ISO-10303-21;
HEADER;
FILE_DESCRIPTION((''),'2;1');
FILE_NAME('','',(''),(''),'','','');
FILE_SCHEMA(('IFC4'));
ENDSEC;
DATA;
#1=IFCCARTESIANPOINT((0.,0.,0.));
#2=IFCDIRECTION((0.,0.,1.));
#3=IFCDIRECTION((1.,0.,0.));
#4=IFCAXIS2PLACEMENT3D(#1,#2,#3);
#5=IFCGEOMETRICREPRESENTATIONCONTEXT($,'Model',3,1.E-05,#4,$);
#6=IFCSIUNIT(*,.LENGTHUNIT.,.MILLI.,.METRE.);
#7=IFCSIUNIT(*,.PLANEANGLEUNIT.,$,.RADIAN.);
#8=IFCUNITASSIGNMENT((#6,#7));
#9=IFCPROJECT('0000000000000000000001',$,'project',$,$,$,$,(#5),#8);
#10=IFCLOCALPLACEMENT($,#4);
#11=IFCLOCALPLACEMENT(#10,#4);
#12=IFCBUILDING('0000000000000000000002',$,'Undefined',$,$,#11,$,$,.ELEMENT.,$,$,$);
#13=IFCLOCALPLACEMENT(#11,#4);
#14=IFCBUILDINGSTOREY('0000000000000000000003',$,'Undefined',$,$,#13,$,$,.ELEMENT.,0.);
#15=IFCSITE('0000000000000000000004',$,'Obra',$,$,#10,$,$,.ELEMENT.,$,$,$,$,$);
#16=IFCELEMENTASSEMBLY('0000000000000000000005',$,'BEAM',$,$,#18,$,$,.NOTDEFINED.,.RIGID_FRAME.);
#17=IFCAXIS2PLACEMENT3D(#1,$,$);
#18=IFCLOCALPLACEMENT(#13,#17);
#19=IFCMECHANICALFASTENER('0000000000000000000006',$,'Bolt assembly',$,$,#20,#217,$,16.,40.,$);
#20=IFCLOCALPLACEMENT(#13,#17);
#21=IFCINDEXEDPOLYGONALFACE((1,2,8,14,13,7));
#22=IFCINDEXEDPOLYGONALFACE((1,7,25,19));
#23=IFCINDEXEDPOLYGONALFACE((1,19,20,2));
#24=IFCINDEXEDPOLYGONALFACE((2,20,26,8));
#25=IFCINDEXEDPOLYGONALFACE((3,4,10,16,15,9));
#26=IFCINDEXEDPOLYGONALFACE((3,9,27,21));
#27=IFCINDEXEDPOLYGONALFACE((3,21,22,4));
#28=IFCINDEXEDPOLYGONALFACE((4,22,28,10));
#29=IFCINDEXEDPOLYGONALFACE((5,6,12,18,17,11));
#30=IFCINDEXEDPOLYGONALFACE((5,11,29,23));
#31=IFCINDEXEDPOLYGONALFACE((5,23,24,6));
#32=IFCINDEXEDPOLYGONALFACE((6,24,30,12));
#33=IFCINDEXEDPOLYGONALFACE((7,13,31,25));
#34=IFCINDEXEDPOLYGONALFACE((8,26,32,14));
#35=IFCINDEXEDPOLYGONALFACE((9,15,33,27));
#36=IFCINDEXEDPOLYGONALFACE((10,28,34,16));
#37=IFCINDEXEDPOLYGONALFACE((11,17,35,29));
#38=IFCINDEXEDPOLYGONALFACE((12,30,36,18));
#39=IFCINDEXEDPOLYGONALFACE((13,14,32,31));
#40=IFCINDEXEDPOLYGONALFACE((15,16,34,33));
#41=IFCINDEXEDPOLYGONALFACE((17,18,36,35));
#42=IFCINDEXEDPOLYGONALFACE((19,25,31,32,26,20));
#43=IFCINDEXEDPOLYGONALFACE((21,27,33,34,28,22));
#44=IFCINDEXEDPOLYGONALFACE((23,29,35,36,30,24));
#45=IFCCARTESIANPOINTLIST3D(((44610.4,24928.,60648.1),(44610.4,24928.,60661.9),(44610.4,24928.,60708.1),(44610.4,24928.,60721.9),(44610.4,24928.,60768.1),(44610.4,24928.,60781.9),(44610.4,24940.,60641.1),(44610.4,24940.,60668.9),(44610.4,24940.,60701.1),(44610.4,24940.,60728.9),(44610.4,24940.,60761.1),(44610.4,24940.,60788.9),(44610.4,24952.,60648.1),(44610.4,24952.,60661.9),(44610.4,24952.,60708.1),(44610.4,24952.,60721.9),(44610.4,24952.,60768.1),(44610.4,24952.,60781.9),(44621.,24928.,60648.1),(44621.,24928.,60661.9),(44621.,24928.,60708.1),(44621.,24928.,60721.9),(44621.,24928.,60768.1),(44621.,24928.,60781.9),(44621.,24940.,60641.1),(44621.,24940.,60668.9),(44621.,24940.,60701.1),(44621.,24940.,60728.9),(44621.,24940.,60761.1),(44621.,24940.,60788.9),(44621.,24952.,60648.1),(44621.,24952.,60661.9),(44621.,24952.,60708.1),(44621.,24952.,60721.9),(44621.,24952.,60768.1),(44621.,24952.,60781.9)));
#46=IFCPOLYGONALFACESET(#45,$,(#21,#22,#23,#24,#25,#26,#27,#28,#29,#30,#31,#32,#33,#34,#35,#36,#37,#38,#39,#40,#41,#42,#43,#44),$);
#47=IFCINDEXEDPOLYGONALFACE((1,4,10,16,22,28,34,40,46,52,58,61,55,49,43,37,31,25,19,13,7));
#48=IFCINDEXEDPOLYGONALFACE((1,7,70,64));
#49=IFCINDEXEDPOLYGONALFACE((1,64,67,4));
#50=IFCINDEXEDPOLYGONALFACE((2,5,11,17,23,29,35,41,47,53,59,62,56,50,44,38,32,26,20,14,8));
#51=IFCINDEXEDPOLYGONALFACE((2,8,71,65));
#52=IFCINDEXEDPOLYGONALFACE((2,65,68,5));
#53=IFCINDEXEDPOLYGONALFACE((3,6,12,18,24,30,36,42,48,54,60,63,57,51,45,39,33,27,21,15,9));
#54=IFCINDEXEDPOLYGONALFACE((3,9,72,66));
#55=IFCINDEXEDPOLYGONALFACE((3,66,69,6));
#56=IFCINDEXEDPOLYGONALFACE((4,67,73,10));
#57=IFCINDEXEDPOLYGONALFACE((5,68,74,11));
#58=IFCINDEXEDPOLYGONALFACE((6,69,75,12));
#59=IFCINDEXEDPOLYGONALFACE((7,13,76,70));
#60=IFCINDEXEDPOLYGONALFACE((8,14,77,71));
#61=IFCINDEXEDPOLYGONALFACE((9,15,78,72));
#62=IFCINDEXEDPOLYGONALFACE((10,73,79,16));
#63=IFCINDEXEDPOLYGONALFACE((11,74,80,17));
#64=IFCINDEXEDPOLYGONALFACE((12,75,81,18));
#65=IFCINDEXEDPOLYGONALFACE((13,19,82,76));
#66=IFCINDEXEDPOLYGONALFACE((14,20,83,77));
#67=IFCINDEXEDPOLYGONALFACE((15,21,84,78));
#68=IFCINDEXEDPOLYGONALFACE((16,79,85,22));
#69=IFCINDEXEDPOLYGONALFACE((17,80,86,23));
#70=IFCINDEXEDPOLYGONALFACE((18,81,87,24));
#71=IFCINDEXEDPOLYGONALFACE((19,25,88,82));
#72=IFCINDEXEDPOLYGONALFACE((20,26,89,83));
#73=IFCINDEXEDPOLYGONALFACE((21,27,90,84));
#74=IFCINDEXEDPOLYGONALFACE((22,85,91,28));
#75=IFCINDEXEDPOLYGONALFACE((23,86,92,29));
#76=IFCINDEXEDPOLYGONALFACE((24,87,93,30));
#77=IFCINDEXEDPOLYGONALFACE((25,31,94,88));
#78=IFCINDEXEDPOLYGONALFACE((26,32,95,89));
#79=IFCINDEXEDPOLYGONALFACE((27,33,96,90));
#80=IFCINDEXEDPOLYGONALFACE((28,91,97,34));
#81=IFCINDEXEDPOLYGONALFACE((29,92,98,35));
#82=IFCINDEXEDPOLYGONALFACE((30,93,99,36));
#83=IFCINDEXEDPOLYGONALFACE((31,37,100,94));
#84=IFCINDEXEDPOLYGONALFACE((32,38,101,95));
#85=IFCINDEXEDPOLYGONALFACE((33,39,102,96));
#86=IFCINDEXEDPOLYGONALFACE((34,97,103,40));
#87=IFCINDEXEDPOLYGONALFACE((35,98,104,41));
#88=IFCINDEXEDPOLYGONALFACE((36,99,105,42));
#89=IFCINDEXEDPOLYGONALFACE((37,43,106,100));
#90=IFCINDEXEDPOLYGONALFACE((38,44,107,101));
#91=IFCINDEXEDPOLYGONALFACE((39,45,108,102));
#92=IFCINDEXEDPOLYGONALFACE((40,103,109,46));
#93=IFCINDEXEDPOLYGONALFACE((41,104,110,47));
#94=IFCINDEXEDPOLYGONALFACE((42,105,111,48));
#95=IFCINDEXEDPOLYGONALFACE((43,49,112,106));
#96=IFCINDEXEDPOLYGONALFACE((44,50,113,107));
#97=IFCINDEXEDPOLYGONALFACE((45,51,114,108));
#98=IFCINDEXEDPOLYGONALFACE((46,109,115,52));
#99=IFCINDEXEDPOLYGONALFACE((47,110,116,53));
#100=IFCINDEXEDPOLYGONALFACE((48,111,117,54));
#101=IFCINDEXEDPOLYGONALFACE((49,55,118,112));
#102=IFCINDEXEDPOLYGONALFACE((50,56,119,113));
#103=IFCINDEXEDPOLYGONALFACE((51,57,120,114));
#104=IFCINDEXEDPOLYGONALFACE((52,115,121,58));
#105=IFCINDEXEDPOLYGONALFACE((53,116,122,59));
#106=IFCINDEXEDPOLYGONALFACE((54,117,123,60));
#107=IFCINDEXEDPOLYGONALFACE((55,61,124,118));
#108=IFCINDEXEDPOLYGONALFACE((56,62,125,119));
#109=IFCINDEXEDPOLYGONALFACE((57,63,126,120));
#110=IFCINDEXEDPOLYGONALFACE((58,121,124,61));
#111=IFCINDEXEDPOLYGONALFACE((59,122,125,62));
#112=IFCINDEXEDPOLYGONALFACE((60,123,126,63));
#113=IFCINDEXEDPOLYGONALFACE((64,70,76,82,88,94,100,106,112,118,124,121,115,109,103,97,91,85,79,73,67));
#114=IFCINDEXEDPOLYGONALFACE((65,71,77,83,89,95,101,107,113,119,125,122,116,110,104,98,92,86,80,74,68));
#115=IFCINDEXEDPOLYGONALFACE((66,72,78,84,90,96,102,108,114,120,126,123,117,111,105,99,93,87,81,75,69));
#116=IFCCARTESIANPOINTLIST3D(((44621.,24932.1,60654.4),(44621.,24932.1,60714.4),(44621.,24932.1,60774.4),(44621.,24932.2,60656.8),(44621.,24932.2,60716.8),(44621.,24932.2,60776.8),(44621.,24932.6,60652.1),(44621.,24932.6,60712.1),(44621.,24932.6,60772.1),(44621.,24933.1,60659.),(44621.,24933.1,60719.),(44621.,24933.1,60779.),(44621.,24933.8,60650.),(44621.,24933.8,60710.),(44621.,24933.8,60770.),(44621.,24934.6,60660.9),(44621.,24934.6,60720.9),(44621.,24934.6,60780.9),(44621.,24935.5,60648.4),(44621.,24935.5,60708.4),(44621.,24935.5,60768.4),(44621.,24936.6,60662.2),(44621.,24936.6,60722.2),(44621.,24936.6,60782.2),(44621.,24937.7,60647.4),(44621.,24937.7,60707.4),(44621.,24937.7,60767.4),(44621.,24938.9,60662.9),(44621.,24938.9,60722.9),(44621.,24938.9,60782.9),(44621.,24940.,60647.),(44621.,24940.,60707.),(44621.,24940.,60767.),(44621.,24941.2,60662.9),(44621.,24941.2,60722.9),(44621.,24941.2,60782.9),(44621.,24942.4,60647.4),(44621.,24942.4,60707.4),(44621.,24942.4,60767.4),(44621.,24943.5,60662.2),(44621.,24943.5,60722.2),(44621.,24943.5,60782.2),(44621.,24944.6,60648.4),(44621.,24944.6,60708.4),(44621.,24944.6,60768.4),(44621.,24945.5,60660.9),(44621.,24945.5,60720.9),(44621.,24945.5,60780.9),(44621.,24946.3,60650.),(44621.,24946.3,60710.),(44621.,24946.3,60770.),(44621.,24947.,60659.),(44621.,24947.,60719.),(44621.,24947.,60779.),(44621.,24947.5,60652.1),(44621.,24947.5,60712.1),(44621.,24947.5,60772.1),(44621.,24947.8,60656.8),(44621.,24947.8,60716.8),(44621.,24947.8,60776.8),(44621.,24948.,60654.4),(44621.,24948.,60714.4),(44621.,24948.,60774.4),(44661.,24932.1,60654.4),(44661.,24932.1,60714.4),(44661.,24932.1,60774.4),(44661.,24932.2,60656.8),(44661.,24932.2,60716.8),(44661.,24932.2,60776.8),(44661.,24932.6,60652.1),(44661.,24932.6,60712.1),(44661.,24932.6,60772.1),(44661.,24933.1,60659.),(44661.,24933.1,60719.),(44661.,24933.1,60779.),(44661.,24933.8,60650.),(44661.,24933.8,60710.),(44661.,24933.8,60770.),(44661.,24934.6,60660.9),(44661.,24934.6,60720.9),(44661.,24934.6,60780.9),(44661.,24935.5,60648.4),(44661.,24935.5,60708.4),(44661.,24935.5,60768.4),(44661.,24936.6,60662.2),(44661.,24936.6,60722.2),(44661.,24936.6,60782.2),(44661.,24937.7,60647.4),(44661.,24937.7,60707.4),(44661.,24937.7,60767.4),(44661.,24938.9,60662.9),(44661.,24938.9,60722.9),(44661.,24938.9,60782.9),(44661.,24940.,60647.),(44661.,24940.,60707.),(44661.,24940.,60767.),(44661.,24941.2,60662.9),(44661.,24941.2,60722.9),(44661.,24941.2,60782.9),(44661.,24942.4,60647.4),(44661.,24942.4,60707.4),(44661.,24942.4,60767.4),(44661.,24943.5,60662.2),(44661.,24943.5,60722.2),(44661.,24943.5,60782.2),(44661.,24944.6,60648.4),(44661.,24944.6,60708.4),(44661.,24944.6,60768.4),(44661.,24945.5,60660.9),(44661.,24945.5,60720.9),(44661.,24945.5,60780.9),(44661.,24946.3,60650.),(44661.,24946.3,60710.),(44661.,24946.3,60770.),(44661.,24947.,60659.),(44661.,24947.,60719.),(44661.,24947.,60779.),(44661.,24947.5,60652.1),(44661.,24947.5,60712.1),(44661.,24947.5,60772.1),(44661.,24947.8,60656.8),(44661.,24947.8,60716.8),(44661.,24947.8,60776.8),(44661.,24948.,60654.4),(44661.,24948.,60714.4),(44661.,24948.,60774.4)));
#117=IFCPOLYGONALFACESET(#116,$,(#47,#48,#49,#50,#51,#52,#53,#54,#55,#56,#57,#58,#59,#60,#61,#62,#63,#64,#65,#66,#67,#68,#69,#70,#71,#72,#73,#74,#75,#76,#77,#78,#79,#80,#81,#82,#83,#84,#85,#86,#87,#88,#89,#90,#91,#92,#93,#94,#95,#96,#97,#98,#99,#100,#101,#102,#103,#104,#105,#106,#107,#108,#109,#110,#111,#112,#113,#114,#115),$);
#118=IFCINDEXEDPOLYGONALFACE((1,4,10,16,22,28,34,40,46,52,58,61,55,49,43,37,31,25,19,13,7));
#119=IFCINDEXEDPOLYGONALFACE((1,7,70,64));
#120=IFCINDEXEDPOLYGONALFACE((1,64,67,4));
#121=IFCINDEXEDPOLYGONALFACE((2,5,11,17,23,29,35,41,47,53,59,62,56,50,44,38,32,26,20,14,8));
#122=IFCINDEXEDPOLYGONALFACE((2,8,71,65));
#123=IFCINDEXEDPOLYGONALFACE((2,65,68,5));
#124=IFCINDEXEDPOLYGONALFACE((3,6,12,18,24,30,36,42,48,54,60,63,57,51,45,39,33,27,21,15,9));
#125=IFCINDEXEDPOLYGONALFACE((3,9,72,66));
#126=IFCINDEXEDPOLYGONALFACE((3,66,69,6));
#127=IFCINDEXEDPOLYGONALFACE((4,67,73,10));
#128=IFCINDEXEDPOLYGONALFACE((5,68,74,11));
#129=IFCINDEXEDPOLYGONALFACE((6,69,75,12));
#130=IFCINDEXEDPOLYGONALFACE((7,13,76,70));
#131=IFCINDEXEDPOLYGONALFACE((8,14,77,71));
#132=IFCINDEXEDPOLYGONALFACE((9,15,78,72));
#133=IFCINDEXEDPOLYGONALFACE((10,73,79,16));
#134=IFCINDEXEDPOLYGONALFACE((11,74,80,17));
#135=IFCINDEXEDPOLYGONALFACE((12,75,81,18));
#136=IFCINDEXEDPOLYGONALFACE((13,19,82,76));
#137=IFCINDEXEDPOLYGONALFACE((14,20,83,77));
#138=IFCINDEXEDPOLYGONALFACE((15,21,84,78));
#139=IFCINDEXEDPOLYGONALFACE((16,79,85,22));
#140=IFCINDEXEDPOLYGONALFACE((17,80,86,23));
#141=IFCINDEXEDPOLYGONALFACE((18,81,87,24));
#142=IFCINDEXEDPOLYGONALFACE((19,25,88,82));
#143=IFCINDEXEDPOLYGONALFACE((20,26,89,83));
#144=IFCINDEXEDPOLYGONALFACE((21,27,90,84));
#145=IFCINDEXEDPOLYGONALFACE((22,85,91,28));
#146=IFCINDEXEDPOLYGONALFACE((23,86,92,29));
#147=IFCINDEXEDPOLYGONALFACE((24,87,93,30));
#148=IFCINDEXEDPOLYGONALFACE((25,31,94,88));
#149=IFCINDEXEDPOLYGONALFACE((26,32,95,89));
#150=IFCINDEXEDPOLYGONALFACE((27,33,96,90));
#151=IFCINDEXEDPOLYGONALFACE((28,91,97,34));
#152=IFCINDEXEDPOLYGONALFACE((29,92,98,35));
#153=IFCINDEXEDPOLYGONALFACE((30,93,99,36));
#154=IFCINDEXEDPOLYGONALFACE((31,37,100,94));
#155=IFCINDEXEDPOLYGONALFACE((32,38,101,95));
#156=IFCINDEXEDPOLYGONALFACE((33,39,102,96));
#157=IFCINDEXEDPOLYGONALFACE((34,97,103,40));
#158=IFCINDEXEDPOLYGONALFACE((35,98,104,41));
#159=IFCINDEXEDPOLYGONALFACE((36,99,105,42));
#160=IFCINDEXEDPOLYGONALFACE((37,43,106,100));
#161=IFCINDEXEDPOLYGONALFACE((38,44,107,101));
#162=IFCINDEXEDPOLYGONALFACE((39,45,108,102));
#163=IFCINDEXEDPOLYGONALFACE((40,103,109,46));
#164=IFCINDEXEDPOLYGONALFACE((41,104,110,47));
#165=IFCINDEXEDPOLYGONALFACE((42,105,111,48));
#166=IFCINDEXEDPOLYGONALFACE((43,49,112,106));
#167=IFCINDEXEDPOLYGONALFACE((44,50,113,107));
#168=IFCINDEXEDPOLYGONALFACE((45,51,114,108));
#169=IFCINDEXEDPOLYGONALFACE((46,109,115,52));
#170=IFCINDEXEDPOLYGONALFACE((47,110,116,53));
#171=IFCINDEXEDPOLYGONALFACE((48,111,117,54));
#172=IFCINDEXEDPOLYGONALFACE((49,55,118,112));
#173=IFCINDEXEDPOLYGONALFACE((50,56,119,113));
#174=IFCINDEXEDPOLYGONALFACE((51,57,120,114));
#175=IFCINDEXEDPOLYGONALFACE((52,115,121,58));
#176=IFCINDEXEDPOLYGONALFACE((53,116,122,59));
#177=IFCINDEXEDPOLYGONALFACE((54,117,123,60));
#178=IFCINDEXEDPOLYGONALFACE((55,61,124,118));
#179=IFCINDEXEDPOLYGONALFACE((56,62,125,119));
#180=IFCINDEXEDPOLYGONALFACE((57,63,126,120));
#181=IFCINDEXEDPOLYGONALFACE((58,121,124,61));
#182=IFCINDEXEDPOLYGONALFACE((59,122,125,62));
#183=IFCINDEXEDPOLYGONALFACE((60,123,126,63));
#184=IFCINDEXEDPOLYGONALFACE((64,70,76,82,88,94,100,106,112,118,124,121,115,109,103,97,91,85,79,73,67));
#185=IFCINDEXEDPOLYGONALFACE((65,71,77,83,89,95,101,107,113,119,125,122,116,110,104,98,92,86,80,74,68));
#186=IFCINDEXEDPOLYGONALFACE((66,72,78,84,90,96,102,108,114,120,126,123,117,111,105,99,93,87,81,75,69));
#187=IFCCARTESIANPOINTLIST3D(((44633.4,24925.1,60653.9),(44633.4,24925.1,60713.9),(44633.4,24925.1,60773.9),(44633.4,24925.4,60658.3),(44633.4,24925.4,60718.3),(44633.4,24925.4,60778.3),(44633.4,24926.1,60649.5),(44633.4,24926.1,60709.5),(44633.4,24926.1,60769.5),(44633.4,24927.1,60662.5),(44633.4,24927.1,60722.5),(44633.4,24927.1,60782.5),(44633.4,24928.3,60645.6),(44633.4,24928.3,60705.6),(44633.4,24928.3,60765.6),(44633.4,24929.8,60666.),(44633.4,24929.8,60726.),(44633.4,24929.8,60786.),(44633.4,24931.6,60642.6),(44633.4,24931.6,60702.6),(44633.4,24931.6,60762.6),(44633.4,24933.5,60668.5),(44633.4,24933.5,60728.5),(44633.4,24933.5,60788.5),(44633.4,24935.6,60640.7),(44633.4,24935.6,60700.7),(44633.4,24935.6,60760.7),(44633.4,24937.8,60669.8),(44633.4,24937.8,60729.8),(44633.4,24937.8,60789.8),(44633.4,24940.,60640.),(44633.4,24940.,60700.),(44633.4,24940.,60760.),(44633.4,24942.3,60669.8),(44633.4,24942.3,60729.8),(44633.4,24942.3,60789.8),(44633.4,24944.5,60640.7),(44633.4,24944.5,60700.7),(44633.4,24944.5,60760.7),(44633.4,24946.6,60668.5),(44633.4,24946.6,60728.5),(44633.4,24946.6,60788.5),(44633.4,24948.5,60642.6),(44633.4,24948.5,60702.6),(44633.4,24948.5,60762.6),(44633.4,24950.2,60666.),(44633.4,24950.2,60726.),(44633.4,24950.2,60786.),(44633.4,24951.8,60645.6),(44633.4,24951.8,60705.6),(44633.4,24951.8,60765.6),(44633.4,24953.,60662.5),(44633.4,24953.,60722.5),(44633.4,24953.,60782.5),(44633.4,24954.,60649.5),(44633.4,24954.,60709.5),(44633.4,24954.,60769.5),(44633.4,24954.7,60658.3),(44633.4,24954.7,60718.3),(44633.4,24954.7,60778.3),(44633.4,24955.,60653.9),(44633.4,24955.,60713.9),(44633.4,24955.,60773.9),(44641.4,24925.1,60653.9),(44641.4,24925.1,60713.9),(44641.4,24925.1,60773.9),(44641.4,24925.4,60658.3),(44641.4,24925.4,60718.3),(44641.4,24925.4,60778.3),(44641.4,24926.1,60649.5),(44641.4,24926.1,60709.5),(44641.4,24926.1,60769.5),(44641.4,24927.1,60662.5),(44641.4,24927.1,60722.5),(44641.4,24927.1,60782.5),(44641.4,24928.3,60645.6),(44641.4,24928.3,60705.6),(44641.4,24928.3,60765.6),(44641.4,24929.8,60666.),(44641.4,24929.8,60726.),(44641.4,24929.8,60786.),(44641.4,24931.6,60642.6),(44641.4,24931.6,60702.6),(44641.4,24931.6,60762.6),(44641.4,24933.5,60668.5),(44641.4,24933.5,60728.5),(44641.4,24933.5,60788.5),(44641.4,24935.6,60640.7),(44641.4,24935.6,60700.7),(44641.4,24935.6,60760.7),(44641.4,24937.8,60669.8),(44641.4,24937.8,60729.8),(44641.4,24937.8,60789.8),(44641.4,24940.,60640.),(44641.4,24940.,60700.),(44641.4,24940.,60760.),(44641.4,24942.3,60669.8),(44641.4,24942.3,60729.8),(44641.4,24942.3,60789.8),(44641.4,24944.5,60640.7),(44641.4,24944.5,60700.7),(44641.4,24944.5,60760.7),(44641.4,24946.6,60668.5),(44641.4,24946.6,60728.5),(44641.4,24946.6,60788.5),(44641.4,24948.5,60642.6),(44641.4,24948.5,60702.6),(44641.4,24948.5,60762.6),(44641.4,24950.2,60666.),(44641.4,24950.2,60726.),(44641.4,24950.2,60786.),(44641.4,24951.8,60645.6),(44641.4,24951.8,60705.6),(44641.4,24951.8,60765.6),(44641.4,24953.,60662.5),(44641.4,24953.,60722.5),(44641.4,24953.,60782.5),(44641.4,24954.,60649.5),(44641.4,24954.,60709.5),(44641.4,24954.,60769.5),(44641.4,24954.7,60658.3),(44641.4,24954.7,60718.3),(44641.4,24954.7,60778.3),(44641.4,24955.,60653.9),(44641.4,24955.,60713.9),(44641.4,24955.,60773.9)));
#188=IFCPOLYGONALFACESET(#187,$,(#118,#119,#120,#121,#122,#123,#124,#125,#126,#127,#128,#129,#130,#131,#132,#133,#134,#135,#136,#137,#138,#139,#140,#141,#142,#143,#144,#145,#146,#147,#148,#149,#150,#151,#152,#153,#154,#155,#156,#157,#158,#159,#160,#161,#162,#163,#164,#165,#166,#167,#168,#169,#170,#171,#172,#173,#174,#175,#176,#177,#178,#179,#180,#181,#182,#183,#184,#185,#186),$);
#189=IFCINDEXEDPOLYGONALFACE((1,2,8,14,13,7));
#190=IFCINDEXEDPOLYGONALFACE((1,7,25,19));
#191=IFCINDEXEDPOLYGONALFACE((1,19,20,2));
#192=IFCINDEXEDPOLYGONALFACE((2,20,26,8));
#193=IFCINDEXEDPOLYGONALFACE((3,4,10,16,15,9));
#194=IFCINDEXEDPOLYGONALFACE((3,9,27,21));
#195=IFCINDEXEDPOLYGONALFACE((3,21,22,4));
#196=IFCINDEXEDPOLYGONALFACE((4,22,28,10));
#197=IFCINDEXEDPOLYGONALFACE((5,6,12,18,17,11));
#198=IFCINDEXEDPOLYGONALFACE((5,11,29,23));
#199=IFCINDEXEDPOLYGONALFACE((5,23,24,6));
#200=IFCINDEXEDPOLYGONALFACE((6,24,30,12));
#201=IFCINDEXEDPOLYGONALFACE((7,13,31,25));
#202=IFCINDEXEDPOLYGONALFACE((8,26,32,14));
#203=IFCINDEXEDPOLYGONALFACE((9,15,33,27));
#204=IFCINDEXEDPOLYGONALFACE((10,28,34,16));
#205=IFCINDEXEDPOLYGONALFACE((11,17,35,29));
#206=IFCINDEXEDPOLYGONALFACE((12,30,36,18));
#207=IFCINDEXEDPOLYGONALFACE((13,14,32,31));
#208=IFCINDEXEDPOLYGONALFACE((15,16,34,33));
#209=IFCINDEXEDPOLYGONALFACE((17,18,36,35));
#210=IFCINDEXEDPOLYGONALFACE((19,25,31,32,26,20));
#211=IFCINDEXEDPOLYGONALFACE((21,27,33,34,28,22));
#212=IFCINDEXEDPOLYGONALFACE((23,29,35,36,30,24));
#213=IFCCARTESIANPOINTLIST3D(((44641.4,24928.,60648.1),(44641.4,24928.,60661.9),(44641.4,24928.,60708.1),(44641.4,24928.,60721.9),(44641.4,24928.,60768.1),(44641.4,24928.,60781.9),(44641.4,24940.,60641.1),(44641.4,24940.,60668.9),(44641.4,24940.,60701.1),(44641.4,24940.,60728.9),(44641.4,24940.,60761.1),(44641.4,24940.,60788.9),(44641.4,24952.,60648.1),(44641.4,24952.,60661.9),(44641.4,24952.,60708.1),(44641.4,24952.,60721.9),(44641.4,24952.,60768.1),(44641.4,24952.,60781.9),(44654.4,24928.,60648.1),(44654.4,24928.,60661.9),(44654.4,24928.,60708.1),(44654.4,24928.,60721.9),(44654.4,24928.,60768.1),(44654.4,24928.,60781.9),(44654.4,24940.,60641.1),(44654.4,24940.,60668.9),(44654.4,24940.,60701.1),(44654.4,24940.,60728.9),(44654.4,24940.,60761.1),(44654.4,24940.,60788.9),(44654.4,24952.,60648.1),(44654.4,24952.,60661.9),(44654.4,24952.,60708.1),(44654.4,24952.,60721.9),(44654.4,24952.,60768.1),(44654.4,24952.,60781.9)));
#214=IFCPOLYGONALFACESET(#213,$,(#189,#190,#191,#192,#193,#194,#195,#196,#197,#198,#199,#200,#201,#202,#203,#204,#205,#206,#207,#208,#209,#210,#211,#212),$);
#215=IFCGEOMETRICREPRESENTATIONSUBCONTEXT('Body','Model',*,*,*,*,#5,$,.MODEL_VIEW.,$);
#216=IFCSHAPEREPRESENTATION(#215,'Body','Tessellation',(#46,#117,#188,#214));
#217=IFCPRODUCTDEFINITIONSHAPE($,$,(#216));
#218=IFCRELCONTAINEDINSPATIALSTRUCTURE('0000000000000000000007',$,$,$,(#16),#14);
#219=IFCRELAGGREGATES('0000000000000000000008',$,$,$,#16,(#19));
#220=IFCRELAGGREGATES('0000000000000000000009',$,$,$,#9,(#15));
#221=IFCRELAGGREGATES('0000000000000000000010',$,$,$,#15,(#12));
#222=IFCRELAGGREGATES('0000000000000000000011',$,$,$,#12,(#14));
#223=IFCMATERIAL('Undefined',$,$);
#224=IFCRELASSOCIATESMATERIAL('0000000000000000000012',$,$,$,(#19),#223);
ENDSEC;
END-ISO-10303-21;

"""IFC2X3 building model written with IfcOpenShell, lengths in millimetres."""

from ifc_helpers import new_model, si_unit, frame, origin_with_axes, origin_2d_with_axis, place, context, subcontext, project, spatial, polyline, circle, outline, extrude, source, transform, mapped, material, element, aggregate, save


model = new_model("IFC2X3")

# Units and contexts
model_context = context("Model", 3, precision=1e-05, world=origin_with_axes())
body_context = subcontext(model_context, "Body", "Model", "MODEL_VIEW")
ifc_project = project(units=[si_unit("LENGTHUNIT", "METRE", prefix="MILLI"), si_unit("PLANEANGLEUNIT", "RADIAN")], contexts=[model_context])

# Site, building, storey
site_placement = place(None, origin_with_axes())
site = spatial("IfcSite", under=ifc_project, at=site_placement, Name="Obra", CompositionType="ELEMENT")
building_placement = place(site_placement, origin_with_axes())
building = spatial("IfcBuilding", under=site, at=building_placement, Name="Undefined", CompositionType="ELEMENT")
storey_placement = place(building_placement, origin_with_axes())
storey = spatial("IfcBuildingStorey", under=building, at=storey_placement, Name="Undefined", CompositionType="ELEMENT", Elevation=0.0)

# Element assembly
ifc_material_1 = material(Name="Undefined")
assembly_1_placement = place(storey_placement, origin_with_axes())
assembly_1 = element("IfcElementAssembly", 1, at=assembly_1_placement, inside=storey, Name="BEAM", AssemblyPlace="NOTDEFINED", PredefinedType="RIGID_FRAME")

# Mechanical fastener
shared_shape_1 = source(origin_with_axes(), body_context, "Body", "SweptSolid", [
    extrude(outline(polyline([(13.9, 0.0), (6.9, 12.0), (-6.9, 12.0), (-13.9, 0.0), (-6.9, -12.0), (6.9, -12.0), (13.9, 0.0)])), frame((0.0, -19.7, 0.0), z_axis=(0.0, 1.0, 0.0), x_axis=(1.0, 0.0, 0.0)), (0.0, 0.0, 1.0), 10.6),
    extrude(circle(Radius=8.0, at=origin_2d_with_axis()), frame((0.0, -9.1, 0.0), z_axis=(0.0, 1.0, 0.0), x_axis=(1.0, 0.0, 0.0)), (0.0, 0.0, 1.0), 40.0),
    extrude(circle(Radius=15.0, at=origin_2d_with_axis()), frame((0.0, 3.3, 0.0), z_axis=(0.0, 1.0, 0.0), x_axis=(1.0, 0.0, 0.0)), (0.0, 0.0, 1.0), 8.0),
    extrude(outline(polyline([(13.9, 0.0), (6.9, 12.0), (-6.9, 12.0), (-13.9, 0.0), (-6.9, -12.0), (6.9, -12.0), (13.9, 0.0)])), frame((0.0, 11.3, 0.0), z_axis=(0.0, 1.0, 0.0), x_axis=(1.0, 0.0, 0.0)), (0.0, 0.0, 1.0), 13.0),
])
mechanical_fastener_1_placement = place(assembly_1_placement, frame((44630.1, 24990.0, 60835.0), z_axis=(0.000002, -1.0, 0.0), x_axis=(0.0, 0.0, -1.0)))
mechanical_fastener_1 = element("IfcMechanicalFastener", 2, at=mechanical_fastener_1_placement, material=ifc_material_1, Name="Bolt assembly", NominalDiameter=16.0, NominalLength=40.0, context=body_context, shape_type="MappedRepresentation", body=[
    mapped(shared_shape_1, transform((60.0, 0.0, 50.0))),
    mapped(shared_shape_1, transform((120.0, 0.0, 50.0))),
    mapped(shared_shape_1, transform((180.0, 0.0, 50.0))),
])
aggregate(assembly_1, [mechanical_fastener_1])

save(model, "model.ifc")
